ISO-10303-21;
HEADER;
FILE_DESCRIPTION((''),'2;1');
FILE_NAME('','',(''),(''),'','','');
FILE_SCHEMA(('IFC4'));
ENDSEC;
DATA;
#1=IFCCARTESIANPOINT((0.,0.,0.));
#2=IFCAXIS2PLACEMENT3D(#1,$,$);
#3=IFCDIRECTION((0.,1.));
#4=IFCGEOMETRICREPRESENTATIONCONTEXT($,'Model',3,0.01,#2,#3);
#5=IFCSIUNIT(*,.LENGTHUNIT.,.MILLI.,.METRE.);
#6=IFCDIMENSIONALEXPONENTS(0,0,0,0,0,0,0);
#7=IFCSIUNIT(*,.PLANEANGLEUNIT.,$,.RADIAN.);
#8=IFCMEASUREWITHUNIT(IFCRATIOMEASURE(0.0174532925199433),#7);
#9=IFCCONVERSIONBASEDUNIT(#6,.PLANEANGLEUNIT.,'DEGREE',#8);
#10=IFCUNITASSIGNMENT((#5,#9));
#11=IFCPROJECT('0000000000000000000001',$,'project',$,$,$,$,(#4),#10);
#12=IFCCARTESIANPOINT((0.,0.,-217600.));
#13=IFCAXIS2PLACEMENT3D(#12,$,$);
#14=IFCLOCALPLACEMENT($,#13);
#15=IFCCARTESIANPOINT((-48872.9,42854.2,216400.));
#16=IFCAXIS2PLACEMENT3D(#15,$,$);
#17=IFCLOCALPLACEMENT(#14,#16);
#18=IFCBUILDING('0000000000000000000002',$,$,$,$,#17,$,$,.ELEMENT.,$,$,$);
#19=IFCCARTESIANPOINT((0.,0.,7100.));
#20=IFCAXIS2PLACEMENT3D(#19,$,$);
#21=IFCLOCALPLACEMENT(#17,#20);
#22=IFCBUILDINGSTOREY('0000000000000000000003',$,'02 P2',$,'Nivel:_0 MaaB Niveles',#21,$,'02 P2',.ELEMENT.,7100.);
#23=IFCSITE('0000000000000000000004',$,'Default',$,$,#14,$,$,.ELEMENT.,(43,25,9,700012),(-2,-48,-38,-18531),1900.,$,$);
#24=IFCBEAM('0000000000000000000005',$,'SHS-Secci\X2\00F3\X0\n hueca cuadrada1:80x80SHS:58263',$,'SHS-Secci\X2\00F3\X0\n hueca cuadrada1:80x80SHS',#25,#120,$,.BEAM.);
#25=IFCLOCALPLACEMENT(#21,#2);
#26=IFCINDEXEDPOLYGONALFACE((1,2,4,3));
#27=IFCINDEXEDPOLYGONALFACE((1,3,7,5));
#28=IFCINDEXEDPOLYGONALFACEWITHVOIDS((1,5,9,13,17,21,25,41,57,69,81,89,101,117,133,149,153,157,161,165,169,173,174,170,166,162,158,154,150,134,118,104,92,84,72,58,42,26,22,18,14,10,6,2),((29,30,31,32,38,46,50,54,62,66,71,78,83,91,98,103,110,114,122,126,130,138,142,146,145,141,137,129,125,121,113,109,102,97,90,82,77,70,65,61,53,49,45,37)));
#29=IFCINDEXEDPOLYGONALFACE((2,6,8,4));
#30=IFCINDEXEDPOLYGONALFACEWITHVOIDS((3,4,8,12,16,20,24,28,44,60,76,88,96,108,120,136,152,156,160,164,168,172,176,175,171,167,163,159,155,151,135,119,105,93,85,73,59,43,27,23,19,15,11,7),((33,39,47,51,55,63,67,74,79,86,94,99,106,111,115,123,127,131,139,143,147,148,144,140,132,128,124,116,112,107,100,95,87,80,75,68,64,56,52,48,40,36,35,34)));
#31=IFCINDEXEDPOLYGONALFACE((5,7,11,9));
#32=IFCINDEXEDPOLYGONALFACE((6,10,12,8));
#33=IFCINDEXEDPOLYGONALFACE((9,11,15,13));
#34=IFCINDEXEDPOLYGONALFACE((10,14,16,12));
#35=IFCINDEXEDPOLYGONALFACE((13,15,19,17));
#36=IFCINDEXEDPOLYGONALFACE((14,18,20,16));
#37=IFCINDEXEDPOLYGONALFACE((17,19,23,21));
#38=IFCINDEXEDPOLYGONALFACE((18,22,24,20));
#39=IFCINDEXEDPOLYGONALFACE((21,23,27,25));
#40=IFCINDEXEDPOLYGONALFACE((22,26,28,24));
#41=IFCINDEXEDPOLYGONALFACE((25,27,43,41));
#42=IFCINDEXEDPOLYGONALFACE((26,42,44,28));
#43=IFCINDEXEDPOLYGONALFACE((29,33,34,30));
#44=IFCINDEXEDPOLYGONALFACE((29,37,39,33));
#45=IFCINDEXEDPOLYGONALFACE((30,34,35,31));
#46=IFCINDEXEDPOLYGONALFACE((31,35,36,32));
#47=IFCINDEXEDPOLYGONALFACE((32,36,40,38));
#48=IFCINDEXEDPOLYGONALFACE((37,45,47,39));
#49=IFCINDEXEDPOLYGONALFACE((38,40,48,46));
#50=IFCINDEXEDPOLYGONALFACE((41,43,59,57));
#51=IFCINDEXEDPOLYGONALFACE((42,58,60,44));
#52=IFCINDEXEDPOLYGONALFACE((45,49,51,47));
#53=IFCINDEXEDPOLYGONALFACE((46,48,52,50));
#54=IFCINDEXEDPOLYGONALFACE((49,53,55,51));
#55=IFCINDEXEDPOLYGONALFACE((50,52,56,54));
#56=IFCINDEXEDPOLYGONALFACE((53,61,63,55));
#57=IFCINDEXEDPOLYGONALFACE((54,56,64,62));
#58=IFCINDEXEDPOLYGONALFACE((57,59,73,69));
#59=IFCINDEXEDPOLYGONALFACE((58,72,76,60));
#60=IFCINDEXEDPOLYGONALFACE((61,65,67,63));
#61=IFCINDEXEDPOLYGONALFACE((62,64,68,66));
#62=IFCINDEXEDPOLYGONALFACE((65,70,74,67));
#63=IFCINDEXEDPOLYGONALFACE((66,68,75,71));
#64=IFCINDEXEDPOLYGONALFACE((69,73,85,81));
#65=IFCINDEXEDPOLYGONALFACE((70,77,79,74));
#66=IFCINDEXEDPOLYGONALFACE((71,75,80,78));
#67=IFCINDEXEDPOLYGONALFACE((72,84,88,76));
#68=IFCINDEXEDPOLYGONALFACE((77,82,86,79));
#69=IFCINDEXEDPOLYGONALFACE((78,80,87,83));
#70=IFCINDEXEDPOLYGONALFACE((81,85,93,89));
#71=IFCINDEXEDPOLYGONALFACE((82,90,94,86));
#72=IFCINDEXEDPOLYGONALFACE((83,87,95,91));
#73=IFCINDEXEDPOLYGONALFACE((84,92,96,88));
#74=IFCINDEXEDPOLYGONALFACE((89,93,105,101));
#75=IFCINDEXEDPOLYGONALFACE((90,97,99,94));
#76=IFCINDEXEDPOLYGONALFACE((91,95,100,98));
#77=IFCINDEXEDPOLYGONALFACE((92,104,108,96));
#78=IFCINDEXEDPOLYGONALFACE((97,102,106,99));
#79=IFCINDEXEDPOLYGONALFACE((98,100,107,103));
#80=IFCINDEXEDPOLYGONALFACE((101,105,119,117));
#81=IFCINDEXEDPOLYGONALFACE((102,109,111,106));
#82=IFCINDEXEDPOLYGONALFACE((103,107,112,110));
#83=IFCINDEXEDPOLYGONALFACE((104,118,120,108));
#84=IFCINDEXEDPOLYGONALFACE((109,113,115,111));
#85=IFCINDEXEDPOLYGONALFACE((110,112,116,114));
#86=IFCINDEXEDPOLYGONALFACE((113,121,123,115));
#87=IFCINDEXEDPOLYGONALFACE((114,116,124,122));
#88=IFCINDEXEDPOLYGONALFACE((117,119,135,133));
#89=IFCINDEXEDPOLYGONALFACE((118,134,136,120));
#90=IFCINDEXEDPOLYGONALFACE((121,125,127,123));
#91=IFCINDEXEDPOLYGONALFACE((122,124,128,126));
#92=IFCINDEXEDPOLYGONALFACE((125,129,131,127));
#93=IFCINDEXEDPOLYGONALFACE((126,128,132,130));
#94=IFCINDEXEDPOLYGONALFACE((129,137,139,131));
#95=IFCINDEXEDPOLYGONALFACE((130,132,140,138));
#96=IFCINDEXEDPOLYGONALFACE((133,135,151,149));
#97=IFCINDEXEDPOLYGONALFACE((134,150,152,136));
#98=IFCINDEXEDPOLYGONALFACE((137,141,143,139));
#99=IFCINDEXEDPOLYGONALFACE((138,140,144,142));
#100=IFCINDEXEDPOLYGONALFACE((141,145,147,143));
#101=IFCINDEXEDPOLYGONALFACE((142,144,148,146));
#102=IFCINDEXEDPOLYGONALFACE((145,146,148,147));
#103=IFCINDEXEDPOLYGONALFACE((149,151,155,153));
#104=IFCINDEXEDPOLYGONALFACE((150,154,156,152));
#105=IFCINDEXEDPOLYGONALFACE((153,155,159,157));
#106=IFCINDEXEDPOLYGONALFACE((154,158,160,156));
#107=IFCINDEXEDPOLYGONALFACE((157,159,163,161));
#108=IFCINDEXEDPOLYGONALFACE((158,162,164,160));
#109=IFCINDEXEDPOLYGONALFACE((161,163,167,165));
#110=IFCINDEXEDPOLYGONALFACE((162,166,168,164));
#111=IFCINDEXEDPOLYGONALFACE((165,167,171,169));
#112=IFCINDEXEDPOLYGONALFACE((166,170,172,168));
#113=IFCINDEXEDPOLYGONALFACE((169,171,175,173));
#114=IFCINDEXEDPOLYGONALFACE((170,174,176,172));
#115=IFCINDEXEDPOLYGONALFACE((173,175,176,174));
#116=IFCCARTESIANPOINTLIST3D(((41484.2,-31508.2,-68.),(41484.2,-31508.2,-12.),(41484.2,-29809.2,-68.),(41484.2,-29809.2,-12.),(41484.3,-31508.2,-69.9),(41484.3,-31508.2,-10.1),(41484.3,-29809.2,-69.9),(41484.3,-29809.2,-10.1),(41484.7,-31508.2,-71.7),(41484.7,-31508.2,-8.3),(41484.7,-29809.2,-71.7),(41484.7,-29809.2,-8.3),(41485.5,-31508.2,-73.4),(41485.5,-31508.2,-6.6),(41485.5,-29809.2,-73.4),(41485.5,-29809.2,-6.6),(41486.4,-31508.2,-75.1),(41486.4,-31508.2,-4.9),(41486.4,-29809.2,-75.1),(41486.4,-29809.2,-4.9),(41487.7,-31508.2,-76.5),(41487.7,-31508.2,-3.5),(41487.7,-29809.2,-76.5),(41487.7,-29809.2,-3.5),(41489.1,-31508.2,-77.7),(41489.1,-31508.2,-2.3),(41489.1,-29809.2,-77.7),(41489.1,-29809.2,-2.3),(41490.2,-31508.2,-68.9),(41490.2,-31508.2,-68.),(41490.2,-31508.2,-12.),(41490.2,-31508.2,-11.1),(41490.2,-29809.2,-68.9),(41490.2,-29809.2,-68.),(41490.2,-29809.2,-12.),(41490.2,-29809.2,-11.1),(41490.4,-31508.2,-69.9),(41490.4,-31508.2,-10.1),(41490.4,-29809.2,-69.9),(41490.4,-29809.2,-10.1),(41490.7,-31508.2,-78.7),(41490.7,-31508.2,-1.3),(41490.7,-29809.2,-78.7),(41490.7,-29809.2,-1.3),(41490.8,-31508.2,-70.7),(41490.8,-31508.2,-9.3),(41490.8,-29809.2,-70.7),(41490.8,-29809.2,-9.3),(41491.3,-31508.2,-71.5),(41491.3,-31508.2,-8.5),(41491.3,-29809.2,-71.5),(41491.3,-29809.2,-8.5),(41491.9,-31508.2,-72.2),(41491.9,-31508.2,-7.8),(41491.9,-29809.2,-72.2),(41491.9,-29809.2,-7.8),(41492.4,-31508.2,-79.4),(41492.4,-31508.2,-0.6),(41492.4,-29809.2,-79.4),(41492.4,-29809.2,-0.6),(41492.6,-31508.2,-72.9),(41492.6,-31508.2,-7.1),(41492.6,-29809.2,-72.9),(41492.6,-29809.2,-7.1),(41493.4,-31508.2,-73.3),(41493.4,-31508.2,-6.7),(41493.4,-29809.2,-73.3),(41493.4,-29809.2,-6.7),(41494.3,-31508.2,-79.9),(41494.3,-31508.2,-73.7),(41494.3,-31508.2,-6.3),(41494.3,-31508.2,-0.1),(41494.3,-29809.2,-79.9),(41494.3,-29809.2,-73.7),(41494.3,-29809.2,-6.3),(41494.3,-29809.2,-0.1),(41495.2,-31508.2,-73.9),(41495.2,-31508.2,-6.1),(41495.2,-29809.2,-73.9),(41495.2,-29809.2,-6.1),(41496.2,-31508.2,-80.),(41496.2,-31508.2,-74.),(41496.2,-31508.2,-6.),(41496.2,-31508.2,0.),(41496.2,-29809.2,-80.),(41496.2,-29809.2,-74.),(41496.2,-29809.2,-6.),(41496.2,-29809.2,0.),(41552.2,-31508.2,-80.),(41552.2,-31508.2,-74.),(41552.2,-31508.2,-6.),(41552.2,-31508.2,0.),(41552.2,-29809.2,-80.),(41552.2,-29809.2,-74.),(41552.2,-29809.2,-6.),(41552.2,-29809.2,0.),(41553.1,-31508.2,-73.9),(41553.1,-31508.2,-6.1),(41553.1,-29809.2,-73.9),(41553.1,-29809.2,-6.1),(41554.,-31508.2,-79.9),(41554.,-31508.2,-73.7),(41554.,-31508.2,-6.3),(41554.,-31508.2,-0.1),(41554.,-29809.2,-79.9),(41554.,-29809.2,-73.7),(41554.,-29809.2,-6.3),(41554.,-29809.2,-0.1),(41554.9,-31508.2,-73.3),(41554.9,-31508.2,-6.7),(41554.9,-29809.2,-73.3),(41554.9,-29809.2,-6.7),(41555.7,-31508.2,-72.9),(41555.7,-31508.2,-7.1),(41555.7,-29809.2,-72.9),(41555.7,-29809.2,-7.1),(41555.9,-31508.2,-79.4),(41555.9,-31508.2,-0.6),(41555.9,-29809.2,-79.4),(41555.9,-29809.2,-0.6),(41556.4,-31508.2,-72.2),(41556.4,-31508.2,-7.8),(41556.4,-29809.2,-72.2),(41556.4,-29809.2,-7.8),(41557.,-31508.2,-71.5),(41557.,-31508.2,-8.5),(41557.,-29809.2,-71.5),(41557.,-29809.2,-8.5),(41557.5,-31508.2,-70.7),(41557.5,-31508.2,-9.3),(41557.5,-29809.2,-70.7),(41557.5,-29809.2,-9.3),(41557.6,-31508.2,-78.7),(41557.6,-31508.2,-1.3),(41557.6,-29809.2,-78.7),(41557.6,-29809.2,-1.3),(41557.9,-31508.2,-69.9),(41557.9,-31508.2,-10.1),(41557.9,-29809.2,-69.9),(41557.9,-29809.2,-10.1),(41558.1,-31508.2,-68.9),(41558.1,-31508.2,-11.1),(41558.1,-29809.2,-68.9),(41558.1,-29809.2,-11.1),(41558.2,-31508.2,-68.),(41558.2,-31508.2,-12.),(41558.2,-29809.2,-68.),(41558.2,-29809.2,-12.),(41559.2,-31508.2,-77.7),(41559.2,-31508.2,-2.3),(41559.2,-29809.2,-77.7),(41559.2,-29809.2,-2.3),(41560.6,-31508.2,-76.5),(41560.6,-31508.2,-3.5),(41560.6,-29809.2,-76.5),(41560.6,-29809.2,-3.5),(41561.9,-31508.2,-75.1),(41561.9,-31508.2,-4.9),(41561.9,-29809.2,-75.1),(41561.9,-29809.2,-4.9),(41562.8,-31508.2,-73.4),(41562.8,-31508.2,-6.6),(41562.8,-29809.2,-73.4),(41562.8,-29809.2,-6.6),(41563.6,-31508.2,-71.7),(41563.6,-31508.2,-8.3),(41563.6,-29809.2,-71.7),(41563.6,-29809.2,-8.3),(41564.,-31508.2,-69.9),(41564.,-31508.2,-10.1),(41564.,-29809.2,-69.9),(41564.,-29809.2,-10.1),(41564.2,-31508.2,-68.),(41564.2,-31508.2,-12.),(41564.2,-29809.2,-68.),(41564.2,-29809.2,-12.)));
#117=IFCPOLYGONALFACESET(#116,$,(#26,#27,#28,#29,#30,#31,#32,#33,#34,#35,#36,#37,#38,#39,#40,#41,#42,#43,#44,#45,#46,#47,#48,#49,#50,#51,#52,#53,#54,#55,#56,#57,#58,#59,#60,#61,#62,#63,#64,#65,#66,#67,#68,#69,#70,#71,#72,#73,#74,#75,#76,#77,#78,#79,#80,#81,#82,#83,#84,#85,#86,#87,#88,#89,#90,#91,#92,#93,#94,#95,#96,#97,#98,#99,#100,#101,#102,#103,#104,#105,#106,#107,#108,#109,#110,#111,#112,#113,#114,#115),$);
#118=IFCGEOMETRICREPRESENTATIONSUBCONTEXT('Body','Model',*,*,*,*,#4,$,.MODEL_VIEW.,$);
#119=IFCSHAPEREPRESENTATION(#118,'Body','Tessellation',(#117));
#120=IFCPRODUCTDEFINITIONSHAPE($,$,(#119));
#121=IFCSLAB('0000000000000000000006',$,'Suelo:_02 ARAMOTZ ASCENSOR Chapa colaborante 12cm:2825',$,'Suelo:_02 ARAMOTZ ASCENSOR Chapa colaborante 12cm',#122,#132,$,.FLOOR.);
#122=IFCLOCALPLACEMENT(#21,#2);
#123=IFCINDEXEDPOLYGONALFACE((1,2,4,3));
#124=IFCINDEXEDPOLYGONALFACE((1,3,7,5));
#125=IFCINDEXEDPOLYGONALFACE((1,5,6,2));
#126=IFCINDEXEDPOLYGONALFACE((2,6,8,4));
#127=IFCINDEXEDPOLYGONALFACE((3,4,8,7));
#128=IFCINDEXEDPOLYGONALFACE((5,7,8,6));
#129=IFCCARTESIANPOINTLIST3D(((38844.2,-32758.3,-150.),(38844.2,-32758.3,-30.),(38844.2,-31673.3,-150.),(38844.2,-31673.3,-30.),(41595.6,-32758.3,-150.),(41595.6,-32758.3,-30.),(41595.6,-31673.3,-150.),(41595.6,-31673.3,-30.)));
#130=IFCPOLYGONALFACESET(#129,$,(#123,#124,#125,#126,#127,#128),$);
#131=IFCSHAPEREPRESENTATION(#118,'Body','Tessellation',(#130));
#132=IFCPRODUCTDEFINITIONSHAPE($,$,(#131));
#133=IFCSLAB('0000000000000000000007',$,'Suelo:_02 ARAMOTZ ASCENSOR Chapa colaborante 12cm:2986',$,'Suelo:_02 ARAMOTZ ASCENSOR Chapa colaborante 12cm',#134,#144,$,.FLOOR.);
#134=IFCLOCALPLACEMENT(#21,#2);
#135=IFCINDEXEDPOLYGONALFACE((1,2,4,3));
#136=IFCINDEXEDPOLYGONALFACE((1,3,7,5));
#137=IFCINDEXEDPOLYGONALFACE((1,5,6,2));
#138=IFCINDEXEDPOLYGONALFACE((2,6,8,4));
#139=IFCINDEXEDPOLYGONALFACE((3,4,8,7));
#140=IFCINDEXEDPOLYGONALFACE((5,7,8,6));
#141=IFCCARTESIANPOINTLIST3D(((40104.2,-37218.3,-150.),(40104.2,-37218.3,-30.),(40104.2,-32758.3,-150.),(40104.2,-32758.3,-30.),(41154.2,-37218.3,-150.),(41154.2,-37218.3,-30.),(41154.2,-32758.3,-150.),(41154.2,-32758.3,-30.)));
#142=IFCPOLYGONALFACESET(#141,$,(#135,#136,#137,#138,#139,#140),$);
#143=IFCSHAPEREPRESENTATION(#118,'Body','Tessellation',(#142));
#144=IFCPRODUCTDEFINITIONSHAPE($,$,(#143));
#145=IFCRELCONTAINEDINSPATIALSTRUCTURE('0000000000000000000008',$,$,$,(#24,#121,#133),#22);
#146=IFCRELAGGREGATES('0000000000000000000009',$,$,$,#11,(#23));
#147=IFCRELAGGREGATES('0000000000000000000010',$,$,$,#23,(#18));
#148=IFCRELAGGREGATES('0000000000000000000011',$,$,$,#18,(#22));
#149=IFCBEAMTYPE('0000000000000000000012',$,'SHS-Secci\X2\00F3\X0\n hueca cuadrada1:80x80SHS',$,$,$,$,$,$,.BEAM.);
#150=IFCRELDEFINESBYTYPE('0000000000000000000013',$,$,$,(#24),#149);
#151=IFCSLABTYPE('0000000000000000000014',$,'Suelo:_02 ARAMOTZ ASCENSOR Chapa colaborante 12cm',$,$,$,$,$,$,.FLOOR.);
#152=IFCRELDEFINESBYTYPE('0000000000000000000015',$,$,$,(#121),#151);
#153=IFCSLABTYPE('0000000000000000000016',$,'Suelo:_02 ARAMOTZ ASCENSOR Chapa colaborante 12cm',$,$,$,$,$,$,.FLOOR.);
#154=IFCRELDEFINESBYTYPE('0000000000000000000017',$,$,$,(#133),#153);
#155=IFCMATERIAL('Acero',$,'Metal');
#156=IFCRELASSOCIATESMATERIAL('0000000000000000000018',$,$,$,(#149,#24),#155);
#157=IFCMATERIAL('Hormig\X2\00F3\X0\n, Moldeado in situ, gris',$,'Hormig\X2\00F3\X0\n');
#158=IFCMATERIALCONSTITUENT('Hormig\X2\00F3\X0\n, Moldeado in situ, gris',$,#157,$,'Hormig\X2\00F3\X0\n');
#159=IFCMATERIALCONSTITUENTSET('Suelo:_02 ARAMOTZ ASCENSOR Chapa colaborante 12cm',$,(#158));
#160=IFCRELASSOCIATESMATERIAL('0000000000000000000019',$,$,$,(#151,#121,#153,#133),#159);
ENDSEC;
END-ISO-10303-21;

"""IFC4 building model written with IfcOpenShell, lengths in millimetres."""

from ifc_helpers import new_model, entity, si_unit, converted_unit, direction, frame, origin, place, context, subcontext, project, spatial, indexed_curve, outline, extrude, source, transform, mapped, material, constituent, constituent_set, type_object, type_shapes, element, save


model = new_model("IFC4")

# Units and contexts
model_context = context("Model", 3, precision=0.01, world=origin(), true_north=direction((0.0, 1.0)))
body_context = subcontext(model_context, "Body", "Model", "MODEL_VIEW")
ifc_project = project(units=[si_unit("LENGTHUNIT", "METRE", prefix="MILLI"), converted_unit("PLANEANGLEUNIT", "DEGREE", entity("IfcRatioMeasure", 0.0174532925199433), si_unit("PLANEANGLEUNIT", "RADIAN"), dimensions=[0, 0, 0, 0, 0, 0, 0])], contexts=[model_context])

# Site, building, storey
site_placement = place(None, frame((0.0, 0.0, -217600.0)))
site = spatial("IfcSite", under=ifc_project, at=site_placement, Name="Default", CompositionType="ELEMENT", RefLatitude=(43, 25, 9, 700012), RefLongitude=(-2, -48, -38, -18531), RefElevation=1900.0)
building_placement = place(site_placement, frame((-48872.9, 42854.2, 216400.0)))
building = spatial("IfcBuilding", under=site, at=building_placement, CompositionType="ELEMENT")
storey_placement = place(building_placement, frame((0.0, 0.0, 7100.0)))
storey = spatial("IfcBuildingStorey", under=building, at=storey_placement, Name="02 P2", ObjectType="Nivel:_0 MaaB Niveles", LongName="02 P2", CompositionType="ELEMENT", Elevation=7100.0)

# Shared definitions
ifc_material_1 = material(Name="Acero", Category="Metal")

# Beam
beam_type_1 = type_object("IfcBeamType", Name="SHS-Sección hueca cuadrada1:80x80SHS", PredefinedType="BEAM", material=ifc_material_1)
shared_shape_1 = source(origin(), body_context, "Body", "SweptSolid", [
    extrude(outline(indexed_curve([(-40.0, -28.0), (-39.9, -29.9), (-39.4, -31.7), (-38.7, -33.4), (-37.7, -35.1), (-36.5, -36.5), (-35.1, -37.7), (-33.4, -38.7), (-31.7, -39.4), (-29.9, -39.9), (-28.0, -40.0), (28.0, -40.0), (29.9, -39.9), (31.7, -39.4), (33.4, -38.7), (35.1, -37.7), (36.5, -36.5), (37.7, -35.1), (38.7, -33.4), (39.4, -31.7), (39.9, -29.9), (40.0, -28.0), (40.0, 28.0), (39.9, 29.9), (39.4, 31.7), (38.7, 33.4), (37.7, 35.1), (36.5, 36.5), (35.1, 37.7), (33.4, 38.7), (31.7, 39.4), (29.9, 39.9), (28.0, 40.0), (-28.0, 40.0), (-29.9, 39.9), (-31.7, 39.4), (-33.4, 38.7), (-35.1, 37.7), (-36.5, 36.5), (-37.7, 35.1), (-38.7, 33.4), (-39.4, 31.7), (-39.9, 29.9), (-40.0, 28.0), (-40.0, -28.0)], self_intersect=False), holes=[indexed_curve([(28.0, -34.0), (-28.0, -34.0), (-28.9, -33.9), (-29.9, -33.7), (-30.7, -33.3), (-31.5, -32.9), (-32.2, -32.2), (-32.9, -31.5), (-33.3, -30.7), (-33.7, -29.9), (-33.9, -28.9), (-34.0, -28.0), (-34.0, 28.0), (-33.9, 28.9), (-33.7, 29.9), (-33.3, 30.7), (-32.9, 31.5), (-32.2, 32.2), (-31.5, 32.9), (-30.7, 33.3), (-29.9, 33.7), (-28.9, 33.9), (-28.0, 34.0), (28.0, 34.0), (28.9, 33.9), (29.9, 33.7), (30.7, 33.3), (31.5, 32.9), (32.2, 32.2), (32.9, 31.5), (33.3, 30.7), (33.7, 29.9), (33.9, 28.9), (34.0, 28.0), (34.0, -28.0), (33.9, -28.9), (33.7, -29.9), (33.3, -30.7), (32.9, -31.5), (32.2, -32.2), (31.5, -32.9), (30.7, -33.3), (29.9, -33.7), (28.9, -33.9), (28.0, -34.0)], self_intersect=False)]), frame((-827.0, 0.0, 0.0), z_axis=(1.0, 0.0, 0.0), x_axis=(0.0, -1.0, 0.0)), (0.0, 0.0, 1.0), 1699.0),
])
type_shapes(beam_type_1, [shared_shape_1])
beam_1_placement = place(storey_placement, frame((41524.2, -30636.2, -40.0), z_axis=(0.0, 0.0, 1.0), x_axis=(0.0, -1.0, 0.0)))
element("IfcBeam", 1, at=beam_1_placement, inside=storey, type_object=beam_type_1, material=ifc_material_1, Name="SHS-Sección hueca cuadrada1:80x80SHS:58263", ObjectType="SHS-Sección hueca cuadrada1:80x80SHS", PredefinedType="BEAM", context=body_context, shape_type="MappedRepresentation", body=[
    mapped(shared_shape_1, transform((0.0, 0.0, 0.0), scale=1.0)),
])

# Slabs
ifc_material_2 = material(Name="Hormigón, Moldeado in situ, gris", Category="Hormigón")
ifc_constituent_1 = constituent(ifc_material_2, Name="Hormigón, Moldeado in situ, gris", Category="Hormigón")
ifc_constituent_set_1 = constituent_set(constituents=[ifc_constituent_1], Name="Suelo:_02 ARAMOTZ ASCENSOR Chapa colaborante 12cm")
slab_type_1 = type_object("IfcSlabType", Name="Suelo:_02 ARAMOTZ ASCENSOR Chapa colaborante 12cm", PredefinedType="FLOOR", material=ifc_constituent_set_1)
slab_1_placement = place(storey_placement, origin())
element("IfcSlab", 2, at=slab_1_placement, inside=storey, type_object=slab_type_1, material=ifc_constituent_set_1, Name="Suelo:_02 ARAMOTZ ASCENSOR Chapa colaborante 12cm:2825", ObjectType="Suelo:_02 ARAMOTZ ASCENSOR Chapa colaborante 12cm", PredefinedType="FLOOR", context=body_context, shape_type="SweptSolid", body=[
    extrude(outline(indexed_curve([(-542.5, -1375.7), (542.5, -1375.7), (542.5, 1375.7), (-542.5, 1375.7), (-542.5, -1375.7)], self_intersect=False)), frame((40219.9, -32215.8, -30.0), z_axis=(0.0, 0.0, -1.0), x_axis=(0.0, -1.0, 0.0)), (0.0, 0.0, 1.0), 120.0),
])
slab_type_2 = type_object("IfcSlabType", Name="Suelo:_02 ARAMOTZ ASCENSOR Chapa colaborante 12cm", PredefinedType="FLOOR", material=ifc_constituent_set_1)
slab_2_placement = place(storey_placement, origin())
element("IfcSlab", 3, at=slab_2_placement, inside=storey, type_object=slab_type_2, material=ifc_constituent_set_1, Name="Suelo:_02 ARAMOTZ ASCENSOR Chapa colaborante 12cm:2986", ObjectType="Suelo:_02 ARAMOTZ ASCENSOR Chapa colaborante 12cm", PredefinedType="FLOOR", context=body_context, shape_type="SweptSolid", body=[
    extrude(outline(indexed_curve([(-525.0, -2230.0), (525.0, -2230.0), (525.0, 2230.0), (-525.0, 2230.0), (-525.0, -2230.0)], self_intersect=False)), frame((40629.2, -34988.3, -30.0), z_axis=(0.0, 0.0, -1.0), x_axis=(1.0, 0.0, 0.0)), (0.0, 0.0, 1.0), 120.0),
])

save(model, "model.ifc")
